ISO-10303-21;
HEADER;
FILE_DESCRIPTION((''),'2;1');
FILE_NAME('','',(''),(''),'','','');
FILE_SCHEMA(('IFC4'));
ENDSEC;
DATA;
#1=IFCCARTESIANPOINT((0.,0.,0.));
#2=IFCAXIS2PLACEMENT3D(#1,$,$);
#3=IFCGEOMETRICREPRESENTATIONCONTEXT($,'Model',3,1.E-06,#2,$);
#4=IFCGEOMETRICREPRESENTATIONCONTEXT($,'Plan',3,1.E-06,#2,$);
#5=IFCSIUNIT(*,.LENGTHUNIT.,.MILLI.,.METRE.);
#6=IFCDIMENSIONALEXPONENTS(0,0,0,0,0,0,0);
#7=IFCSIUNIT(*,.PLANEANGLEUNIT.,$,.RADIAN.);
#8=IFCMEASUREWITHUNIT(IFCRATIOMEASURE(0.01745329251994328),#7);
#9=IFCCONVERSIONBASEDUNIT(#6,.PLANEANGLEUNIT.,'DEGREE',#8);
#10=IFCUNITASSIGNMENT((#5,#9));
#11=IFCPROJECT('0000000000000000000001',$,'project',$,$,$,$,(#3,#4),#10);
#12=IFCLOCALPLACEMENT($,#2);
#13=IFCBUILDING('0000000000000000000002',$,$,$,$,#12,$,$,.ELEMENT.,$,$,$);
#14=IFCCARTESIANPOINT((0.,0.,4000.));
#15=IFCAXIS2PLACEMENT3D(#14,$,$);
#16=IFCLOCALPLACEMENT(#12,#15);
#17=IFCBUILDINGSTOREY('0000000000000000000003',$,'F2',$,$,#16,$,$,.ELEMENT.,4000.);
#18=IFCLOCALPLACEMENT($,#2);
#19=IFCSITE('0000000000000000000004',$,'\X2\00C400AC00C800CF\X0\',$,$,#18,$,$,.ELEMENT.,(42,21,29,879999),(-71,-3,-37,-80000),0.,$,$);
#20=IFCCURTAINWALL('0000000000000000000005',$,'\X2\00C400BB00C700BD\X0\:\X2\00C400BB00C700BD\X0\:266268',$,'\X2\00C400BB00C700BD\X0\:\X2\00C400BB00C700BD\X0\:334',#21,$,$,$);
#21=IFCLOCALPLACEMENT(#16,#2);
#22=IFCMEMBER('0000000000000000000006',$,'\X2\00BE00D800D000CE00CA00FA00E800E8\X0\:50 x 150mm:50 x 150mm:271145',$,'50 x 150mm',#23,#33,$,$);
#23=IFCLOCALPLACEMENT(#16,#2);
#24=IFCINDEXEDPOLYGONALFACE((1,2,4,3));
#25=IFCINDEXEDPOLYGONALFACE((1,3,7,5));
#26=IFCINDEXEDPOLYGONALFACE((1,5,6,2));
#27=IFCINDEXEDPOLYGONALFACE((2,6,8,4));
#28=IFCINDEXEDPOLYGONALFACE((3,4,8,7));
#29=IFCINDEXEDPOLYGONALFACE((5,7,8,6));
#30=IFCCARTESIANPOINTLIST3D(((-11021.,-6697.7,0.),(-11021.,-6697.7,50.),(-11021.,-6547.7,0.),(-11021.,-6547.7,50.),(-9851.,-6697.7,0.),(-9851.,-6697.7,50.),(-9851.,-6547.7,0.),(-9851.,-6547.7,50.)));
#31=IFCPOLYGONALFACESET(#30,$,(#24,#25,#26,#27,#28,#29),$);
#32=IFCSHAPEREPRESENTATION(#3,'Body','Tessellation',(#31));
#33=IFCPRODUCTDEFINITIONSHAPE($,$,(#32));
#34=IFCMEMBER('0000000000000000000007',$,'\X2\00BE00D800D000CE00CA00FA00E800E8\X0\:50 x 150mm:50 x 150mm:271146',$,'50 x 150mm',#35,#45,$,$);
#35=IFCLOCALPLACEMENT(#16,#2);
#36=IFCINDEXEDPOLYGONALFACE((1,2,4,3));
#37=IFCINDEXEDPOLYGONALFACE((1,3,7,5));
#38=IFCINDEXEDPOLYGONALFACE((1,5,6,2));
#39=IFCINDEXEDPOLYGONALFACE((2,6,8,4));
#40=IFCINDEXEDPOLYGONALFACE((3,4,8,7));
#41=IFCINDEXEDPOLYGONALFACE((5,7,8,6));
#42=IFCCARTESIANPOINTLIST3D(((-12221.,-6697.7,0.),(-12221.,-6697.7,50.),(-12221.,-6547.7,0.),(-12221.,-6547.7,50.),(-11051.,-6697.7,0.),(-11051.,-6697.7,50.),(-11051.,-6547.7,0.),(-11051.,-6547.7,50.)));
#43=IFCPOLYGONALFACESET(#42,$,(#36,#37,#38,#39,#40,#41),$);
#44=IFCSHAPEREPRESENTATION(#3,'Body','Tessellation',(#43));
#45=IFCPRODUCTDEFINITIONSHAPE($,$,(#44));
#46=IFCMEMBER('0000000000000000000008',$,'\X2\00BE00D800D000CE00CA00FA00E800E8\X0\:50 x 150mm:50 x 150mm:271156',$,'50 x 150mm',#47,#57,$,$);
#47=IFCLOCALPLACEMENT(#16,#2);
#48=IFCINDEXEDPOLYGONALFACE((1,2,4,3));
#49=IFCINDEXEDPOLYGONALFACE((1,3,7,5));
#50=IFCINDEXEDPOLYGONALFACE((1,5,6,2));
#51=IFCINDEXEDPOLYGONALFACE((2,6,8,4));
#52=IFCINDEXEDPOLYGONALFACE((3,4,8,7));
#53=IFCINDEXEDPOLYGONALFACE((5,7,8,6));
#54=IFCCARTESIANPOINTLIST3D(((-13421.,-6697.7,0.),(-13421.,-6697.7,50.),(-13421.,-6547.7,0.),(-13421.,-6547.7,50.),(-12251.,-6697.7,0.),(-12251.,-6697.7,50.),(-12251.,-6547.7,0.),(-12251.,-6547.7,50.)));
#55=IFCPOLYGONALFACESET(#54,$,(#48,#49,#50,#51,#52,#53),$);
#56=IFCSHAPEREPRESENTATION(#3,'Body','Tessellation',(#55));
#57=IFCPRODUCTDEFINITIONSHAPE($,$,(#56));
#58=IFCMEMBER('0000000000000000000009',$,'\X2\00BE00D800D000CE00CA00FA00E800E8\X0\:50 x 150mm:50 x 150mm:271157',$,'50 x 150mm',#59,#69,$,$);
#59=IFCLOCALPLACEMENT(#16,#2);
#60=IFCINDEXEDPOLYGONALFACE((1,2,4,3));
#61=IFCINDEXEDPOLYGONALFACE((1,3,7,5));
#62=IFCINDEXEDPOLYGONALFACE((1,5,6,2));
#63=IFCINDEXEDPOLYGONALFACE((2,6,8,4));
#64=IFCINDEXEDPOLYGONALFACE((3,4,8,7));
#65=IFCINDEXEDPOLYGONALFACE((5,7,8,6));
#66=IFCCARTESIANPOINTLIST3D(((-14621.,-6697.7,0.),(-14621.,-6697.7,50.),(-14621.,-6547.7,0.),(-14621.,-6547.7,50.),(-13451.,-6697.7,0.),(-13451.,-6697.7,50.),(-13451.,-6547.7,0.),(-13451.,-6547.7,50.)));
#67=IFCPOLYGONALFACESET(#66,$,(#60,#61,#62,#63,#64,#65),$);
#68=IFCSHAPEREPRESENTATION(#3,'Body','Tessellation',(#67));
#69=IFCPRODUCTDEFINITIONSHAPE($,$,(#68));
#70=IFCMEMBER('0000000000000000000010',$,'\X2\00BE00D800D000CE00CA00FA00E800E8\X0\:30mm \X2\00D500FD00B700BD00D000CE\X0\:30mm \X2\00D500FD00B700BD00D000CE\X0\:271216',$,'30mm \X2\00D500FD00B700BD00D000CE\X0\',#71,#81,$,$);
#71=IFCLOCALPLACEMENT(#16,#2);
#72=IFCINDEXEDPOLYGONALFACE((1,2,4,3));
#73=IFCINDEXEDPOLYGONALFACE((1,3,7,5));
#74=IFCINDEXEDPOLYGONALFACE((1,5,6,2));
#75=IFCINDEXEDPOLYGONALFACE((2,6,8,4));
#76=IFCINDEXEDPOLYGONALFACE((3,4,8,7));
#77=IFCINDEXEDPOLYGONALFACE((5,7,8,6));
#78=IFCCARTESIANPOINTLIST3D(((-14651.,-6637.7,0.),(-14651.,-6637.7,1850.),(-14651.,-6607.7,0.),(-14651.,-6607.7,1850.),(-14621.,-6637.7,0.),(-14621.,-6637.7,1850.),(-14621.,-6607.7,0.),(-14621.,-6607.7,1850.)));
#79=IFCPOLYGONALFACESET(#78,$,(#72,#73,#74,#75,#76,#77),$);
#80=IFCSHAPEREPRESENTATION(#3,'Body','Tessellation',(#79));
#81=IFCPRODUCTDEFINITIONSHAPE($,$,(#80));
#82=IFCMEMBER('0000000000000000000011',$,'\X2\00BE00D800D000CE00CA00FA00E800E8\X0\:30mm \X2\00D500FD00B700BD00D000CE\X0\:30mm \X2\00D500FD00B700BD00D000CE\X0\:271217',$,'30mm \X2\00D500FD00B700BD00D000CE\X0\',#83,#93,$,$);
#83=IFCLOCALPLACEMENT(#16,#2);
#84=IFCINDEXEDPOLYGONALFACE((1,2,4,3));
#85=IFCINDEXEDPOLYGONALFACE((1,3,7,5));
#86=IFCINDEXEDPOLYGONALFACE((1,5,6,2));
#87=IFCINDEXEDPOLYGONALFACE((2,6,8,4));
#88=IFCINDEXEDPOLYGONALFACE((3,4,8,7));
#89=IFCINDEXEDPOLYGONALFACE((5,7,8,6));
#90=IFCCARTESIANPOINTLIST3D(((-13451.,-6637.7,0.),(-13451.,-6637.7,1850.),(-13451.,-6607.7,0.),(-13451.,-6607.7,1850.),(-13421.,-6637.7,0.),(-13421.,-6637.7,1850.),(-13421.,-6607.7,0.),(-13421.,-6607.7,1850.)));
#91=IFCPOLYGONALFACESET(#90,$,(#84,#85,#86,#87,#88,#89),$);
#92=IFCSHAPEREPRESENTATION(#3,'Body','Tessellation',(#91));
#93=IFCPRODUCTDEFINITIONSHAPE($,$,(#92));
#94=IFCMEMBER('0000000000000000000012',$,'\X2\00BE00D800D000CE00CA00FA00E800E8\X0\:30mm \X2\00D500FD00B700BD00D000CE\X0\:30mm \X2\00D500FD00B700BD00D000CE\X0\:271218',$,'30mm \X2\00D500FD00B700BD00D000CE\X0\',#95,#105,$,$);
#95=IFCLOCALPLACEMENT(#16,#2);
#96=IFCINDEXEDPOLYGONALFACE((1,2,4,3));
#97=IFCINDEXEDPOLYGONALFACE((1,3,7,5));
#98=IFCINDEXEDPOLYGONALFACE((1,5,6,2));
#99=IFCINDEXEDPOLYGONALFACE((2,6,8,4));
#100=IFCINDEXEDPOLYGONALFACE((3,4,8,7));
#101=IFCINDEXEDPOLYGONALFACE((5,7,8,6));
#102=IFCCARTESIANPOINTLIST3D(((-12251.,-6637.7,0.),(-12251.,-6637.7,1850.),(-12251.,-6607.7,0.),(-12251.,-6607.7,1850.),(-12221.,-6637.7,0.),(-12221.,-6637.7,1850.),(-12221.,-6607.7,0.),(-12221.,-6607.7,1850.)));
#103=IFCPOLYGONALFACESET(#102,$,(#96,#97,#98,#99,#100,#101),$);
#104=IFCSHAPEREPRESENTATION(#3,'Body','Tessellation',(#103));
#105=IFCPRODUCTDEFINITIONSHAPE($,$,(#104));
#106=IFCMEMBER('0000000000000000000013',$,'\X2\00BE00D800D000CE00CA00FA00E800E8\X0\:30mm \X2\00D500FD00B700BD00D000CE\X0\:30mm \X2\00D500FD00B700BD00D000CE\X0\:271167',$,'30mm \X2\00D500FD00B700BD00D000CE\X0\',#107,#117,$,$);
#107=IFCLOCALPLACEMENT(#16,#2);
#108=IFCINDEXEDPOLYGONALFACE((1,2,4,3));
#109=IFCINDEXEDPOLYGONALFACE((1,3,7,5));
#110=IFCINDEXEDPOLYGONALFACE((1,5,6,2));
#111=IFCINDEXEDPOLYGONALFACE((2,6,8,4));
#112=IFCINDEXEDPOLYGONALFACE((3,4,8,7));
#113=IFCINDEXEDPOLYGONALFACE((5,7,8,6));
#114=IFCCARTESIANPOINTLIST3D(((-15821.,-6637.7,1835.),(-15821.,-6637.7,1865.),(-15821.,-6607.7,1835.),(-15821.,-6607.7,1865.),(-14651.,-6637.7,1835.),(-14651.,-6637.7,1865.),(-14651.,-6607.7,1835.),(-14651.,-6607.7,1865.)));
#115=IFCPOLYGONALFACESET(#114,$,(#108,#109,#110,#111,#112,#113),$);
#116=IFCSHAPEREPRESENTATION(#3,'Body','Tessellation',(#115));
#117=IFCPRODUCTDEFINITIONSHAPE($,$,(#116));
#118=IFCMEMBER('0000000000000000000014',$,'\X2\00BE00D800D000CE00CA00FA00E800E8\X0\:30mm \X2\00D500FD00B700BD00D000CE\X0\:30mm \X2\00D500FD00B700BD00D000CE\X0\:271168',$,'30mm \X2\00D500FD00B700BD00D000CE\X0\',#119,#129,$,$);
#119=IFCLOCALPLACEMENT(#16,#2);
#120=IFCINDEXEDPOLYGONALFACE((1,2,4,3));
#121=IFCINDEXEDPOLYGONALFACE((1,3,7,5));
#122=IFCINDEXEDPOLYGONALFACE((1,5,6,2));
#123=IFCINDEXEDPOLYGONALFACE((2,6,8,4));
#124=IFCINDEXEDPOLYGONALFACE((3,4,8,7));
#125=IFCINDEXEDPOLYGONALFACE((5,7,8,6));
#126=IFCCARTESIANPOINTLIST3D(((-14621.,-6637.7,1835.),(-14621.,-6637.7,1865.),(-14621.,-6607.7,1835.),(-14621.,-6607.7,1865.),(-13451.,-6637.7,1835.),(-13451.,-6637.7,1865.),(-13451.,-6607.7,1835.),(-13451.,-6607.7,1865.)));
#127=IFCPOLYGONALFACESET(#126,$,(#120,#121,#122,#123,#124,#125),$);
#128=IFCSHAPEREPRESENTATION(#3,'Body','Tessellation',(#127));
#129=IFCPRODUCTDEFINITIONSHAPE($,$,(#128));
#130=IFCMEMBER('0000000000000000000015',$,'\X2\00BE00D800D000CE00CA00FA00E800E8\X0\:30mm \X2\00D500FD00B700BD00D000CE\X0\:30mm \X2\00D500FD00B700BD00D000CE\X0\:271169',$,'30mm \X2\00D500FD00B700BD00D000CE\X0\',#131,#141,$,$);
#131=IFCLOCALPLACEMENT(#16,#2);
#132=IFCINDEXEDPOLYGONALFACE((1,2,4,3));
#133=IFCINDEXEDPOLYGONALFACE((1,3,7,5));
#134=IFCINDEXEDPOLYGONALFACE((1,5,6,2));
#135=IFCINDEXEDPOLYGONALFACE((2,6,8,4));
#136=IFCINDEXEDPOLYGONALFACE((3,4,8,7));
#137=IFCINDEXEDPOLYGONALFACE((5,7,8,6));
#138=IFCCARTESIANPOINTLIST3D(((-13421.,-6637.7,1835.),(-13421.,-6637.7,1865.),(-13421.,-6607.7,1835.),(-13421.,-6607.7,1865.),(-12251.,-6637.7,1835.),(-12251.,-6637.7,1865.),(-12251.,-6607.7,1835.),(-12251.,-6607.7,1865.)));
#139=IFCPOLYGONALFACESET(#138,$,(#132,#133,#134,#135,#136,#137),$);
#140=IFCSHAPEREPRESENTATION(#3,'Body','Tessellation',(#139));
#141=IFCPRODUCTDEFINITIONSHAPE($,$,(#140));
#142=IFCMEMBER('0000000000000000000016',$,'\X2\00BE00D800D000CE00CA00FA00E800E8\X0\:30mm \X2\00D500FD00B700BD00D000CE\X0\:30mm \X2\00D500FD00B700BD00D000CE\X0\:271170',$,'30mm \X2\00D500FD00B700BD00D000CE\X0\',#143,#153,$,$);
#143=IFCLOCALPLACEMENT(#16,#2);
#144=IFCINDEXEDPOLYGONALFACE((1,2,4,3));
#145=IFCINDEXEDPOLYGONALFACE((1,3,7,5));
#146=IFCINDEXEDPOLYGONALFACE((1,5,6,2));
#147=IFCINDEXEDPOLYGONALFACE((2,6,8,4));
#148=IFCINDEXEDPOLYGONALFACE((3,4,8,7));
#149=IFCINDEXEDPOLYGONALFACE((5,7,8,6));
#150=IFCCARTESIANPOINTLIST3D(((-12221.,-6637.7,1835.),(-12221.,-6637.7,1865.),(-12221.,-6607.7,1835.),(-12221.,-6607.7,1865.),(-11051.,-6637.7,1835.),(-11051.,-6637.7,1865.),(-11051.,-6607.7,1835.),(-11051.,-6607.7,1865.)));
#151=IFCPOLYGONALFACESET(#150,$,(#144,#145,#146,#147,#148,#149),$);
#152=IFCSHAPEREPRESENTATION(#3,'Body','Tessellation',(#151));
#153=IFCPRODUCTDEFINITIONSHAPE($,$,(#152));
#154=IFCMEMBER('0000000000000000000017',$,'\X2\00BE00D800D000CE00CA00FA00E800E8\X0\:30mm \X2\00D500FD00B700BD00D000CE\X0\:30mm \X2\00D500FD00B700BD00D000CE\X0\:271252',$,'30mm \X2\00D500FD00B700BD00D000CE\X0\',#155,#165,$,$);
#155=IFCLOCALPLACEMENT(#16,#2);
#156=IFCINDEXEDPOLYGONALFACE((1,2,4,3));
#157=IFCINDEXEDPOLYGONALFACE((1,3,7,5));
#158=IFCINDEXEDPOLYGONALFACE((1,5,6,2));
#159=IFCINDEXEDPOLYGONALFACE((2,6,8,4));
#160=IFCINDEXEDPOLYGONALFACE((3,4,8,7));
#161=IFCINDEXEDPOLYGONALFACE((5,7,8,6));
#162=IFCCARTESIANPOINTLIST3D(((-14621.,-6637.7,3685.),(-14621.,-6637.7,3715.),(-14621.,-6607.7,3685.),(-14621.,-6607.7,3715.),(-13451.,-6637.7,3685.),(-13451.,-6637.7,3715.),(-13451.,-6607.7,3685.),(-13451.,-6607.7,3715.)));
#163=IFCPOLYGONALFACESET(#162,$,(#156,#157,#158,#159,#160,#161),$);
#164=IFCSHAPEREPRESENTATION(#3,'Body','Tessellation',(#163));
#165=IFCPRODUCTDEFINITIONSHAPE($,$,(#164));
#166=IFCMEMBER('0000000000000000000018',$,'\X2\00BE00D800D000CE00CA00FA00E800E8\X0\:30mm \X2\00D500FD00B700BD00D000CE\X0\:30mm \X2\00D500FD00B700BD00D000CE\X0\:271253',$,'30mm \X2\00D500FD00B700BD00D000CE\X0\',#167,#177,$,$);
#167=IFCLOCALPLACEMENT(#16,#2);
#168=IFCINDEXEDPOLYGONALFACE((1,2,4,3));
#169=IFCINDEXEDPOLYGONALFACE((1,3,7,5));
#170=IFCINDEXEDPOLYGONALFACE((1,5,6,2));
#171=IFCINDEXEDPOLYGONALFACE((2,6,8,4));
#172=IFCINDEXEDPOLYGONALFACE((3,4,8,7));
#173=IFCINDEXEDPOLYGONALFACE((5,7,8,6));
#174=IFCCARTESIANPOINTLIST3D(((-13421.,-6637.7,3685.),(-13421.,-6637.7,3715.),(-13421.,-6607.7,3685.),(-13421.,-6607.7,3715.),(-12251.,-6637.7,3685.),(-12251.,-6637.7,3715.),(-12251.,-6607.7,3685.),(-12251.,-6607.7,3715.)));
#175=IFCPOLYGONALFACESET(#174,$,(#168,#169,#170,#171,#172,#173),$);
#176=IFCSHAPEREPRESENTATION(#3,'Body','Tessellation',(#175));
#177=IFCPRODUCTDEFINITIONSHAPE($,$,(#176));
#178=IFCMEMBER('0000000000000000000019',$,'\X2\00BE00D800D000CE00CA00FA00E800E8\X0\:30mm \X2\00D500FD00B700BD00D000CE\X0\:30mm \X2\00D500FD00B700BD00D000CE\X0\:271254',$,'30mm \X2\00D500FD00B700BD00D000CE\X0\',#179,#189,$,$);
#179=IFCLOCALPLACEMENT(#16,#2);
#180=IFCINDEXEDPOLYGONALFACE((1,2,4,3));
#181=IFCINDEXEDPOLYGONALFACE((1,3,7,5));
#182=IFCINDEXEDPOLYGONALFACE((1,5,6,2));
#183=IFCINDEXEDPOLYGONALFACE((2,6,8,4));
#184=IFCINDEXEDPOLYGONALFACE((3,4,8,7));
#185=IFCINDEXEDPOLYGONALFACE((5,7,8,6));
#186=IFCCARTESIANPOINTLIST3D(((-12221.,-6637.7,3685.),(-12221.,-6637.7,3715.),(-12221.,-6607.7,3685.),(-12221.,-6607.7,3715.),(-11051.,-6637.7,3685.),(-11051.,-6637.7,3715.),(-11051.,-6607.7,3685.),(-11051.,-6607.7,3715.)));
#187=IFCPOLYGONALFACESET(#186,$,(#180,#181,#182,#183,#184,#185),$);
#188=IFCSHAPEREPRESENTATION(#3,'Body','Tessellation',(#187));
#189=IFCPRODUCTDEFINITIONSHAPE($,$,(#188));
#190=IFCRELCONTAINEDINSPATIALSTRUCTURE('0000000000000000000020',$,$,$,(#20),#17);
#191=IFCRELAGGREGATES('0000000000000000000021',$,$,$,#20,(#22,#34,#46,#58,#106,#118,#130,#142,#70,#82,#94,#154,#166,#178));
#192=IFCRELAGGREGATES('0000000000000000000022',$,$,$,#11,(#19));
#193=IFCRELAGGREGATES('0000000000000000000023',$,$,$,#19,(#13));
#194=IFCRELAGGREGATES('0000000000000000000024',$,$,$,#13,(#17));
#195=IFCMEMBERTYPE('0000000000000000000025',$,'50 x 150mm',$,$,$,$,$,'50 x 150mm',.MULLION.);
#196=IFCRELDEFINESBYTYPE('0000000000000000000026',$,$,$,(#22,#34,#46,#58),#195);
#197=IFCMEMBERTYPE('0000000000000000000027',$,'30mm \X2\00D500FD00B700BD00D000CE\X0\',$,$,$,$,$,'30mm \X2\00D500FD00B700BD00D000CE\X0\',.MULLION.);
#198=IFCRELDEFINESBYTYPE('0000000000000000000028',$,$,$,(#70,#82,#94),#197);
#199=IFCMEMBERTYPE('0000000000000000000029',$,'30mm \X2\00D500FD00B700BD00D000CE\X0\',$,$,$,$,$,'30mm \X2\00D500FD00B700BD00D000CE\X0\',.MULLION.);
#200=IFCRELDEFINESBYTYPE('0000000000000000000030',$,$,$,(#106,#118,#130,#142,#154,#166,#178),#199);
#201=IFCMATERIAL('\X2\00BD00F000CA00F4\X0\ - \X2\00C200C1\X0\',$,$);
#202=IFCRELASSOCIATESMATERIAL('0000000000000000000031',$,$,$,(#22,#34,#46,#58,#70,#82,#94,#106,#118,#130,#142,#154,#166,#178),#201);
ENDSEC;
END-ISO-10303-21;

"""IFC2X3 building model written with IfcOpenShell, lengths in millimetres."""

from ifc_helpers import new_model, entity, si_unit, converted_unit, frame, origin, origin_2d_with_axis, place, context, project, spatial, rectangle, extrude, source, transform, mapped, material, type_object, type_shapes, element, aggregate, save


model = new_model("IFC2X3")

# Units and contexts
model_context = context("Model", 3, precision=1e-06, world=origin())
plan_context = context("Plan", 3, precision=1e-06, world=origin())
ifc_project = project(units=[si_unit("LENGTHUNIT", "METRE", prefix="MILLI"), converted_unit("PLANEANGLEUNIT", "DEGREE", entity("IfcRatioMeasure", 0.01745329251994328), si_unit("PLANEANGLEUNIT", "RADIAN"), dimensions=[0, 0, 0, 0, 0, 0, 0])], contexts=[model_context, plan_context])

# Site, building, storey
site_placement = place(None, origin())
site = spatial("IfcSite", under=ifc_project, at=site_placement, Name="Ä¬ÈÏ", CompositionType="ELEMENT", RefLatitude=(42, 21, 29, 879999), RefLongitude=(-71, -3, -37, -80000), RefElevation=0.0)
building_placement = place(None, origin())
building = spatial("IfcBuilding", under=site, at=building_placement, CompositionType="ELEMENT")
storey_placement = place(building_placement, frame((0.0, 0.0, 4000.0)))
storey = spatial("IfcBuildingStorey", under=building, at=storey_placement, Name="F2", CompositionType="ELEMENT", Elevation=4000.0)

# Curtain wall, members
curtain_wall_placement = place(storey_placement, origin())
curtain_wall = element("IfcCurtainWall", 1, at=curtain_wall_placement, inside=storey, Name="Ä»Ç½:Ä»Ç½:266268", ObjectType="Ä»Ç½:Ä»Ç½:334")
ifc_material_1 = material(Name="½ðÊô - ÂÁ")
member_type_1 = type_object("IfcMemberType", Name="50 x 150mm", ElementType="50 x 150mm", PredefinedType="MULLION")
shared_shape_1 = source(origin(), model_context, "Body", "SweptSolid", [
    extrude(rectangle(XDim=50.0, YDim=150.0, at=origin_2d_with_axis()), frame((-25.0, 0.0, -1170.0), z_axis=(0.0, 0.0, 1.0), x_axis=(-1.0, 0.0, 0.0)), (0.0, 0.0, 1.0), 1170.0),
])
type_shapes(member_type_1, [shared_shape_1])
member_1_placement = place(storey_placement, frame((-11021.0, -6622.7, 0.0), z_axis=(-1.0, 0.0, 0.0), x_axis=(0.0, 0.0, -1.0)))
member_1 = element("IfcMember", 2, at=member_1_placement, type_object=member_type_1, material=ifc_material_1, Name="¾ØÐÎÊúèè:50 x 150mm:50 x 150mm:271145", ObjectType="50 x 150mm", context=model_context, shape_type="MappedRepresentation", body=[
    mapped(shared_shape_1, transform((0.0, 0.0, 0.0), scale=1.0)),
])
member_2_placement = place(storey_placement, frame((-12221.0, -6622.7, 0.0), z_axis=(-1.0, 0.0, 0.0), x_axis=(0.0, 0.0, -1.0)))
member_2 = element("IfcMember", 3, at=member_2_placement, type_object=member_type_1, material=ifc_material_1, Name="¾ØÐÎÊúèè:50 x 150mm:50 x 150mm:271146", ObjectType="50 x 150mm", context=model_context, shape_type="MappedRepresentation", body=[
    mapped(shared_shape_1, transform((0.0, 0.0, 0.0), scale=1.0)),
])
member_3_placement = place(storey_placement, frame((-13421.0, -6622.7, 0.0), z_axis=(-1.0, 0.0, 0.0), x_axis=(0.0, 0.0, -1.0)))
member_3 = element("IfcMember", 4, at=member_3_placement, type_object=member_type_1, material=ifc_material_1, Name="¾ØÐÎÊúèè:50 x 150mm:50 x 150mm:271156", ObjectType="50 x 150mm", context=model_context, shape_type="MappedRepresentation", body=[
    mapped(shared_shape_1, transform((0.0, 0.0, 0.0), scale=1.0)),
])
member_4_placement = place(storey_placement, frame((-14621.0, -6622.7, 0.0), z_axis=(-1.0, 0.0, 0.0), x_axis=(0.0, 0.0, -1.0)))
member_4 = element("IfcMember", 5, at=member_4_placement, type_object=member_type_1, material=ifc_material_1, Name="¾ØÐÎÊúèè:50 x 150mm:50 x 150mm:271157", ObjectType="50 x 150mm", context=model_context, shape_type="MappedRepresentation", body=[
    mapped(shared_shape_1, transform((0.0, 0.0, 0.0), scale=1.0)),
])
member_type_2 = type_object("IfcMemberType", Name="30mm Õý·½ÐÎ", ElementType="30mm Õý·½ÐÎ", PredefinedType="MULLION")
shared_shape_2 = source(origin(), model_context, "Body", "SweptSolid", [
    extrude(rectangle(XDim=30.0, YDim=30.0, at=origin_2d_with_axis()), frame((0.0, 0.0, -1850.0), z_axis=(0.0, 0.0, 1.0), x_axis=(-1.0, 0.0, 0.0)), (0.0, 0.0, 1.0), 1850.0),
])
type_shapes(member_type_2, [shared_shape_2])
member_5_placement = place(storey_placement, frame((-14636.0, -6622.7, 0.0), z_axis=(0.0, 0.0, -1.0), x_axis=(1.0, 0.0, 0.0)))
member_5 = element("IfcMember", 6, at=member_5_placement, type_object=member_type_2, material=ifc_material_1, Name="¾ØÐÎÊúèè:30mm Õý·½ÐÎ:30mm Õý·½ÐÎ:271216", ObjectType="30mm Õý·½ÐÎ", context=model_context, shape_type="MappedRepresentation", body=[
    mapped(shared_shape_2, transform((0.0, 0.0, 0.0), scale=1.0)),
])
member_6_placement = place(storey_placement, frame((-13436.0, -6622.7, 0.0), z_axis=(0.0, 0.0, -1.0), x_axis=(1.0, 0.0, 0.0)))
member_6 = element("IfcMember", 7, at=member_6_placement, type_object=member_type_2, material=ifc_material_1, Name="¾ØÐÎÊúèè:30mm Õý·½ÐÎ:30mm Õý·½ÐÎ:271217", ObjectType="30mm Õý·½ÐÎ", context=model_context, shape_type="MappedRepresentation", body=[
    mapped(shared_shape_2, transform((0.0, 0.0, 0.0), scale=1.0)),
])
member_7_placement = place(storey_placement, frame((-12236.0, -6622.7, 0.0), z_axis=(0.0, 0.0, -1.0), x_axis=(1.0, 0.0, 0.0)))
member_7 = element("IfcMember", 8, at=member_7_placement, type_object=member_type_2, material=ifc_material_1, Name="¾ØÐÎÊúèè:30mm Õý·½ÐÎ:30mm Õý·½ÐÎ:271218", ObjectType="30mm Õý·½ÐÎ", context=model_context, shape_type="MappedRepresentation", body=[
    mapped(shared_shape_2, transform((0.0, 0.0, 0.0), scale=1.0)),
])
member_type_3 = type_object("IfcMemberType", Name="30mm Õý·½ÐÎ", ElementType="30mm Õý·½ÐÎ", PredefinedType="MULLION")
shared_shape_3 = source(origin(), model_context, "Body", "SweptSolid", [
    extrude(rectangle(XDim=30.0, YDim=30.0, at=origin_2d_with_axis()), frame((0.0, 0.0, -1170.0), z_axis=(0.0, 0.0, 1.0), x_axis=(-1.0, 0.0, 0.0)), (0.0, 0.0, 1.0), 1170.0),
])
type_shapes(member_type_3, [shared_shape_3])
member_8_placement = place(storey_placement, frame((-14651.0, -6622.7, 1850.0), z_axis=(1.0, 0.0, 0.0), x_axis=(0.0, 0.0, 1.0)))
member_8 = element("IfcMember", 9, at=member_8_placement, type_object=member_type_3, material=ifc_material_1, Name="¾ØÐÎÊúèè:30mm Õý·½ÐÎ:30mm Õý·½ÐÎ:271167", ObjectType="30mm Õý·½ÐÎ", context=model_context, shape_type="MappedRepresentation", body=[
    mapped(shared_shape_3, transform((0.0, 0.0, 0.0), scale=1.0)),
])
member_9_placement = place(storey_placement, frame((-13451.0, -6622.7, 1850.0), z_axis=(1.0, 0.0, 0.0), x_axis=(0.0, 0.0, 1.0)))
member_9 = element("IfcMember", 10, at=member_9_placement, type_object=member_type_3, material=ifc_material_1, Name="¾ØÐÎÊúèè:30mm Õý·½ÐÎ:30mm Õý·½ÐÎ:271168", ObjectType="30mm Õý·½ÐÎ", context=model_context, shape_type="MappedRepresentation", body=[
    mapped(shared_shape_3, transform((0.0, 0.0, 0.0), scale=1.0)),
])
member_10_placement = place(storey_placement, frame((-12251.0, -6622.7, 1850.0), z_axis=(1.0, 0.0, 0.0), x_axis=(0.0, 0.0, 1.0)))
member_10 = element("IfcMember", 11, at=member_10_placement, type_object=member_type_3, material=ifc_material_1, Name="¾ØÐÎÊúèè:30mm Õý·½ÐÎ:30mm Õý·½ÐÎ:271169", ObjectType="30mm Õý·½ÐÎ", context=model_context, shape_type="MappedRepresentation", body=[
    mapped(shared_shape_3, transform((0.0, 0.0, 0.0), scale=1.0)),
])
member_11_placement = place(storey_placement, frame((-11051.0, -6622.7, 1850.0), z_axis=(1.0, 0.0, 0.0), x_axis=(0.0, 0.0, 1.0)))
member_11 = element("IfcMember", 12, at=member_11_placement, type_object=member_type_3, material=ifc_material_1, Name="¾ØÐÎÊúèè:30mm Õý·½ÐÎ:30mm Õý·½ÐÎ:271170", ObjectType="30mm Õý·½ÐÎ", context=model_context, shape_type="MappedRepresentation", body=[
    mapped(shared_shape_3, transform((0.0, 0.0, 0.0), scale=1.0)),
])
placement = place(building_placement, frame((0.0, 0.0, 7700.0)))
member_12_placement = place(placement, frame((-13451.0, -6622.7, 0.0), z_axis=(1.0, 0.0, 0.0), x_axis=(0.0, 0.0, 1.0)))
member_12 = element("IfcMember", 13, at=member_12_placement, type_object=member_type_3, material=ifc_material_1, Name="¾ØÐÎÊúèè:30mm Õý·½ÐÎ:30mm Õý·½ÐÎ:271252", ObjectType="30mm Õý·½ÐÎ", context=model_context, shape_type="MappedRepresentation", body=[
    mapped(shared_shape_3, transform((0.0, 0.0, 0.0), scale=1.0)),
])
member_13_placement = place(placement, frame((-12251.0, -6622.7, 0.0), z_axis=(1.0, 0.0, 0.0), x_axis=(0.0, 0.0, 1.0)))
member_13 = element("IfcMember", 14, at=member_13_placement, type_object=member_type_3, material=ifc_material_1, Name="¾ØÐÎÊúèè:30mm Õý·½ÐÎ:30mm Õý·½ÐÎ:271253", ObjectType="30mm Õý·½ÐÎ", context=model_context, shape_type="MappedRepresentation", body=[
    mapped(shared_shape_3, transform((0.0, 0.0, 0.0), scale=1.0)),
])
member_14_placement = place(placement, frame((-11051.0, -6622.7, 0.0), z_axis=(1.0, 0.0, 0.0), x_axis=(0.0, 0.0, 1.0)))
member_14 = element("IfcMember", 15, at=member_14_placement, type_object=member_type_3, material=ifc_material_1, Name="¾ØÐÎÊúèè:30mm Õý·½ÐÎ:30mm Õý·½ÐÎ:271254", ObjectType="30mm Õý·½ÐÎ", context=model_context, shape_type="MappedRepresentation", body=[
    mapped(shared_shape_3, transform((0.0, 0.0, 0.0), scale=1.0)),
])
aggregate(curtain_wall, [member_1, member_2, member_3, member_4, member_8, member_9, member_10, member_11, member_5, member_6, member_7, member_12, member_13, member_14])

save(model, "model.ifc")
